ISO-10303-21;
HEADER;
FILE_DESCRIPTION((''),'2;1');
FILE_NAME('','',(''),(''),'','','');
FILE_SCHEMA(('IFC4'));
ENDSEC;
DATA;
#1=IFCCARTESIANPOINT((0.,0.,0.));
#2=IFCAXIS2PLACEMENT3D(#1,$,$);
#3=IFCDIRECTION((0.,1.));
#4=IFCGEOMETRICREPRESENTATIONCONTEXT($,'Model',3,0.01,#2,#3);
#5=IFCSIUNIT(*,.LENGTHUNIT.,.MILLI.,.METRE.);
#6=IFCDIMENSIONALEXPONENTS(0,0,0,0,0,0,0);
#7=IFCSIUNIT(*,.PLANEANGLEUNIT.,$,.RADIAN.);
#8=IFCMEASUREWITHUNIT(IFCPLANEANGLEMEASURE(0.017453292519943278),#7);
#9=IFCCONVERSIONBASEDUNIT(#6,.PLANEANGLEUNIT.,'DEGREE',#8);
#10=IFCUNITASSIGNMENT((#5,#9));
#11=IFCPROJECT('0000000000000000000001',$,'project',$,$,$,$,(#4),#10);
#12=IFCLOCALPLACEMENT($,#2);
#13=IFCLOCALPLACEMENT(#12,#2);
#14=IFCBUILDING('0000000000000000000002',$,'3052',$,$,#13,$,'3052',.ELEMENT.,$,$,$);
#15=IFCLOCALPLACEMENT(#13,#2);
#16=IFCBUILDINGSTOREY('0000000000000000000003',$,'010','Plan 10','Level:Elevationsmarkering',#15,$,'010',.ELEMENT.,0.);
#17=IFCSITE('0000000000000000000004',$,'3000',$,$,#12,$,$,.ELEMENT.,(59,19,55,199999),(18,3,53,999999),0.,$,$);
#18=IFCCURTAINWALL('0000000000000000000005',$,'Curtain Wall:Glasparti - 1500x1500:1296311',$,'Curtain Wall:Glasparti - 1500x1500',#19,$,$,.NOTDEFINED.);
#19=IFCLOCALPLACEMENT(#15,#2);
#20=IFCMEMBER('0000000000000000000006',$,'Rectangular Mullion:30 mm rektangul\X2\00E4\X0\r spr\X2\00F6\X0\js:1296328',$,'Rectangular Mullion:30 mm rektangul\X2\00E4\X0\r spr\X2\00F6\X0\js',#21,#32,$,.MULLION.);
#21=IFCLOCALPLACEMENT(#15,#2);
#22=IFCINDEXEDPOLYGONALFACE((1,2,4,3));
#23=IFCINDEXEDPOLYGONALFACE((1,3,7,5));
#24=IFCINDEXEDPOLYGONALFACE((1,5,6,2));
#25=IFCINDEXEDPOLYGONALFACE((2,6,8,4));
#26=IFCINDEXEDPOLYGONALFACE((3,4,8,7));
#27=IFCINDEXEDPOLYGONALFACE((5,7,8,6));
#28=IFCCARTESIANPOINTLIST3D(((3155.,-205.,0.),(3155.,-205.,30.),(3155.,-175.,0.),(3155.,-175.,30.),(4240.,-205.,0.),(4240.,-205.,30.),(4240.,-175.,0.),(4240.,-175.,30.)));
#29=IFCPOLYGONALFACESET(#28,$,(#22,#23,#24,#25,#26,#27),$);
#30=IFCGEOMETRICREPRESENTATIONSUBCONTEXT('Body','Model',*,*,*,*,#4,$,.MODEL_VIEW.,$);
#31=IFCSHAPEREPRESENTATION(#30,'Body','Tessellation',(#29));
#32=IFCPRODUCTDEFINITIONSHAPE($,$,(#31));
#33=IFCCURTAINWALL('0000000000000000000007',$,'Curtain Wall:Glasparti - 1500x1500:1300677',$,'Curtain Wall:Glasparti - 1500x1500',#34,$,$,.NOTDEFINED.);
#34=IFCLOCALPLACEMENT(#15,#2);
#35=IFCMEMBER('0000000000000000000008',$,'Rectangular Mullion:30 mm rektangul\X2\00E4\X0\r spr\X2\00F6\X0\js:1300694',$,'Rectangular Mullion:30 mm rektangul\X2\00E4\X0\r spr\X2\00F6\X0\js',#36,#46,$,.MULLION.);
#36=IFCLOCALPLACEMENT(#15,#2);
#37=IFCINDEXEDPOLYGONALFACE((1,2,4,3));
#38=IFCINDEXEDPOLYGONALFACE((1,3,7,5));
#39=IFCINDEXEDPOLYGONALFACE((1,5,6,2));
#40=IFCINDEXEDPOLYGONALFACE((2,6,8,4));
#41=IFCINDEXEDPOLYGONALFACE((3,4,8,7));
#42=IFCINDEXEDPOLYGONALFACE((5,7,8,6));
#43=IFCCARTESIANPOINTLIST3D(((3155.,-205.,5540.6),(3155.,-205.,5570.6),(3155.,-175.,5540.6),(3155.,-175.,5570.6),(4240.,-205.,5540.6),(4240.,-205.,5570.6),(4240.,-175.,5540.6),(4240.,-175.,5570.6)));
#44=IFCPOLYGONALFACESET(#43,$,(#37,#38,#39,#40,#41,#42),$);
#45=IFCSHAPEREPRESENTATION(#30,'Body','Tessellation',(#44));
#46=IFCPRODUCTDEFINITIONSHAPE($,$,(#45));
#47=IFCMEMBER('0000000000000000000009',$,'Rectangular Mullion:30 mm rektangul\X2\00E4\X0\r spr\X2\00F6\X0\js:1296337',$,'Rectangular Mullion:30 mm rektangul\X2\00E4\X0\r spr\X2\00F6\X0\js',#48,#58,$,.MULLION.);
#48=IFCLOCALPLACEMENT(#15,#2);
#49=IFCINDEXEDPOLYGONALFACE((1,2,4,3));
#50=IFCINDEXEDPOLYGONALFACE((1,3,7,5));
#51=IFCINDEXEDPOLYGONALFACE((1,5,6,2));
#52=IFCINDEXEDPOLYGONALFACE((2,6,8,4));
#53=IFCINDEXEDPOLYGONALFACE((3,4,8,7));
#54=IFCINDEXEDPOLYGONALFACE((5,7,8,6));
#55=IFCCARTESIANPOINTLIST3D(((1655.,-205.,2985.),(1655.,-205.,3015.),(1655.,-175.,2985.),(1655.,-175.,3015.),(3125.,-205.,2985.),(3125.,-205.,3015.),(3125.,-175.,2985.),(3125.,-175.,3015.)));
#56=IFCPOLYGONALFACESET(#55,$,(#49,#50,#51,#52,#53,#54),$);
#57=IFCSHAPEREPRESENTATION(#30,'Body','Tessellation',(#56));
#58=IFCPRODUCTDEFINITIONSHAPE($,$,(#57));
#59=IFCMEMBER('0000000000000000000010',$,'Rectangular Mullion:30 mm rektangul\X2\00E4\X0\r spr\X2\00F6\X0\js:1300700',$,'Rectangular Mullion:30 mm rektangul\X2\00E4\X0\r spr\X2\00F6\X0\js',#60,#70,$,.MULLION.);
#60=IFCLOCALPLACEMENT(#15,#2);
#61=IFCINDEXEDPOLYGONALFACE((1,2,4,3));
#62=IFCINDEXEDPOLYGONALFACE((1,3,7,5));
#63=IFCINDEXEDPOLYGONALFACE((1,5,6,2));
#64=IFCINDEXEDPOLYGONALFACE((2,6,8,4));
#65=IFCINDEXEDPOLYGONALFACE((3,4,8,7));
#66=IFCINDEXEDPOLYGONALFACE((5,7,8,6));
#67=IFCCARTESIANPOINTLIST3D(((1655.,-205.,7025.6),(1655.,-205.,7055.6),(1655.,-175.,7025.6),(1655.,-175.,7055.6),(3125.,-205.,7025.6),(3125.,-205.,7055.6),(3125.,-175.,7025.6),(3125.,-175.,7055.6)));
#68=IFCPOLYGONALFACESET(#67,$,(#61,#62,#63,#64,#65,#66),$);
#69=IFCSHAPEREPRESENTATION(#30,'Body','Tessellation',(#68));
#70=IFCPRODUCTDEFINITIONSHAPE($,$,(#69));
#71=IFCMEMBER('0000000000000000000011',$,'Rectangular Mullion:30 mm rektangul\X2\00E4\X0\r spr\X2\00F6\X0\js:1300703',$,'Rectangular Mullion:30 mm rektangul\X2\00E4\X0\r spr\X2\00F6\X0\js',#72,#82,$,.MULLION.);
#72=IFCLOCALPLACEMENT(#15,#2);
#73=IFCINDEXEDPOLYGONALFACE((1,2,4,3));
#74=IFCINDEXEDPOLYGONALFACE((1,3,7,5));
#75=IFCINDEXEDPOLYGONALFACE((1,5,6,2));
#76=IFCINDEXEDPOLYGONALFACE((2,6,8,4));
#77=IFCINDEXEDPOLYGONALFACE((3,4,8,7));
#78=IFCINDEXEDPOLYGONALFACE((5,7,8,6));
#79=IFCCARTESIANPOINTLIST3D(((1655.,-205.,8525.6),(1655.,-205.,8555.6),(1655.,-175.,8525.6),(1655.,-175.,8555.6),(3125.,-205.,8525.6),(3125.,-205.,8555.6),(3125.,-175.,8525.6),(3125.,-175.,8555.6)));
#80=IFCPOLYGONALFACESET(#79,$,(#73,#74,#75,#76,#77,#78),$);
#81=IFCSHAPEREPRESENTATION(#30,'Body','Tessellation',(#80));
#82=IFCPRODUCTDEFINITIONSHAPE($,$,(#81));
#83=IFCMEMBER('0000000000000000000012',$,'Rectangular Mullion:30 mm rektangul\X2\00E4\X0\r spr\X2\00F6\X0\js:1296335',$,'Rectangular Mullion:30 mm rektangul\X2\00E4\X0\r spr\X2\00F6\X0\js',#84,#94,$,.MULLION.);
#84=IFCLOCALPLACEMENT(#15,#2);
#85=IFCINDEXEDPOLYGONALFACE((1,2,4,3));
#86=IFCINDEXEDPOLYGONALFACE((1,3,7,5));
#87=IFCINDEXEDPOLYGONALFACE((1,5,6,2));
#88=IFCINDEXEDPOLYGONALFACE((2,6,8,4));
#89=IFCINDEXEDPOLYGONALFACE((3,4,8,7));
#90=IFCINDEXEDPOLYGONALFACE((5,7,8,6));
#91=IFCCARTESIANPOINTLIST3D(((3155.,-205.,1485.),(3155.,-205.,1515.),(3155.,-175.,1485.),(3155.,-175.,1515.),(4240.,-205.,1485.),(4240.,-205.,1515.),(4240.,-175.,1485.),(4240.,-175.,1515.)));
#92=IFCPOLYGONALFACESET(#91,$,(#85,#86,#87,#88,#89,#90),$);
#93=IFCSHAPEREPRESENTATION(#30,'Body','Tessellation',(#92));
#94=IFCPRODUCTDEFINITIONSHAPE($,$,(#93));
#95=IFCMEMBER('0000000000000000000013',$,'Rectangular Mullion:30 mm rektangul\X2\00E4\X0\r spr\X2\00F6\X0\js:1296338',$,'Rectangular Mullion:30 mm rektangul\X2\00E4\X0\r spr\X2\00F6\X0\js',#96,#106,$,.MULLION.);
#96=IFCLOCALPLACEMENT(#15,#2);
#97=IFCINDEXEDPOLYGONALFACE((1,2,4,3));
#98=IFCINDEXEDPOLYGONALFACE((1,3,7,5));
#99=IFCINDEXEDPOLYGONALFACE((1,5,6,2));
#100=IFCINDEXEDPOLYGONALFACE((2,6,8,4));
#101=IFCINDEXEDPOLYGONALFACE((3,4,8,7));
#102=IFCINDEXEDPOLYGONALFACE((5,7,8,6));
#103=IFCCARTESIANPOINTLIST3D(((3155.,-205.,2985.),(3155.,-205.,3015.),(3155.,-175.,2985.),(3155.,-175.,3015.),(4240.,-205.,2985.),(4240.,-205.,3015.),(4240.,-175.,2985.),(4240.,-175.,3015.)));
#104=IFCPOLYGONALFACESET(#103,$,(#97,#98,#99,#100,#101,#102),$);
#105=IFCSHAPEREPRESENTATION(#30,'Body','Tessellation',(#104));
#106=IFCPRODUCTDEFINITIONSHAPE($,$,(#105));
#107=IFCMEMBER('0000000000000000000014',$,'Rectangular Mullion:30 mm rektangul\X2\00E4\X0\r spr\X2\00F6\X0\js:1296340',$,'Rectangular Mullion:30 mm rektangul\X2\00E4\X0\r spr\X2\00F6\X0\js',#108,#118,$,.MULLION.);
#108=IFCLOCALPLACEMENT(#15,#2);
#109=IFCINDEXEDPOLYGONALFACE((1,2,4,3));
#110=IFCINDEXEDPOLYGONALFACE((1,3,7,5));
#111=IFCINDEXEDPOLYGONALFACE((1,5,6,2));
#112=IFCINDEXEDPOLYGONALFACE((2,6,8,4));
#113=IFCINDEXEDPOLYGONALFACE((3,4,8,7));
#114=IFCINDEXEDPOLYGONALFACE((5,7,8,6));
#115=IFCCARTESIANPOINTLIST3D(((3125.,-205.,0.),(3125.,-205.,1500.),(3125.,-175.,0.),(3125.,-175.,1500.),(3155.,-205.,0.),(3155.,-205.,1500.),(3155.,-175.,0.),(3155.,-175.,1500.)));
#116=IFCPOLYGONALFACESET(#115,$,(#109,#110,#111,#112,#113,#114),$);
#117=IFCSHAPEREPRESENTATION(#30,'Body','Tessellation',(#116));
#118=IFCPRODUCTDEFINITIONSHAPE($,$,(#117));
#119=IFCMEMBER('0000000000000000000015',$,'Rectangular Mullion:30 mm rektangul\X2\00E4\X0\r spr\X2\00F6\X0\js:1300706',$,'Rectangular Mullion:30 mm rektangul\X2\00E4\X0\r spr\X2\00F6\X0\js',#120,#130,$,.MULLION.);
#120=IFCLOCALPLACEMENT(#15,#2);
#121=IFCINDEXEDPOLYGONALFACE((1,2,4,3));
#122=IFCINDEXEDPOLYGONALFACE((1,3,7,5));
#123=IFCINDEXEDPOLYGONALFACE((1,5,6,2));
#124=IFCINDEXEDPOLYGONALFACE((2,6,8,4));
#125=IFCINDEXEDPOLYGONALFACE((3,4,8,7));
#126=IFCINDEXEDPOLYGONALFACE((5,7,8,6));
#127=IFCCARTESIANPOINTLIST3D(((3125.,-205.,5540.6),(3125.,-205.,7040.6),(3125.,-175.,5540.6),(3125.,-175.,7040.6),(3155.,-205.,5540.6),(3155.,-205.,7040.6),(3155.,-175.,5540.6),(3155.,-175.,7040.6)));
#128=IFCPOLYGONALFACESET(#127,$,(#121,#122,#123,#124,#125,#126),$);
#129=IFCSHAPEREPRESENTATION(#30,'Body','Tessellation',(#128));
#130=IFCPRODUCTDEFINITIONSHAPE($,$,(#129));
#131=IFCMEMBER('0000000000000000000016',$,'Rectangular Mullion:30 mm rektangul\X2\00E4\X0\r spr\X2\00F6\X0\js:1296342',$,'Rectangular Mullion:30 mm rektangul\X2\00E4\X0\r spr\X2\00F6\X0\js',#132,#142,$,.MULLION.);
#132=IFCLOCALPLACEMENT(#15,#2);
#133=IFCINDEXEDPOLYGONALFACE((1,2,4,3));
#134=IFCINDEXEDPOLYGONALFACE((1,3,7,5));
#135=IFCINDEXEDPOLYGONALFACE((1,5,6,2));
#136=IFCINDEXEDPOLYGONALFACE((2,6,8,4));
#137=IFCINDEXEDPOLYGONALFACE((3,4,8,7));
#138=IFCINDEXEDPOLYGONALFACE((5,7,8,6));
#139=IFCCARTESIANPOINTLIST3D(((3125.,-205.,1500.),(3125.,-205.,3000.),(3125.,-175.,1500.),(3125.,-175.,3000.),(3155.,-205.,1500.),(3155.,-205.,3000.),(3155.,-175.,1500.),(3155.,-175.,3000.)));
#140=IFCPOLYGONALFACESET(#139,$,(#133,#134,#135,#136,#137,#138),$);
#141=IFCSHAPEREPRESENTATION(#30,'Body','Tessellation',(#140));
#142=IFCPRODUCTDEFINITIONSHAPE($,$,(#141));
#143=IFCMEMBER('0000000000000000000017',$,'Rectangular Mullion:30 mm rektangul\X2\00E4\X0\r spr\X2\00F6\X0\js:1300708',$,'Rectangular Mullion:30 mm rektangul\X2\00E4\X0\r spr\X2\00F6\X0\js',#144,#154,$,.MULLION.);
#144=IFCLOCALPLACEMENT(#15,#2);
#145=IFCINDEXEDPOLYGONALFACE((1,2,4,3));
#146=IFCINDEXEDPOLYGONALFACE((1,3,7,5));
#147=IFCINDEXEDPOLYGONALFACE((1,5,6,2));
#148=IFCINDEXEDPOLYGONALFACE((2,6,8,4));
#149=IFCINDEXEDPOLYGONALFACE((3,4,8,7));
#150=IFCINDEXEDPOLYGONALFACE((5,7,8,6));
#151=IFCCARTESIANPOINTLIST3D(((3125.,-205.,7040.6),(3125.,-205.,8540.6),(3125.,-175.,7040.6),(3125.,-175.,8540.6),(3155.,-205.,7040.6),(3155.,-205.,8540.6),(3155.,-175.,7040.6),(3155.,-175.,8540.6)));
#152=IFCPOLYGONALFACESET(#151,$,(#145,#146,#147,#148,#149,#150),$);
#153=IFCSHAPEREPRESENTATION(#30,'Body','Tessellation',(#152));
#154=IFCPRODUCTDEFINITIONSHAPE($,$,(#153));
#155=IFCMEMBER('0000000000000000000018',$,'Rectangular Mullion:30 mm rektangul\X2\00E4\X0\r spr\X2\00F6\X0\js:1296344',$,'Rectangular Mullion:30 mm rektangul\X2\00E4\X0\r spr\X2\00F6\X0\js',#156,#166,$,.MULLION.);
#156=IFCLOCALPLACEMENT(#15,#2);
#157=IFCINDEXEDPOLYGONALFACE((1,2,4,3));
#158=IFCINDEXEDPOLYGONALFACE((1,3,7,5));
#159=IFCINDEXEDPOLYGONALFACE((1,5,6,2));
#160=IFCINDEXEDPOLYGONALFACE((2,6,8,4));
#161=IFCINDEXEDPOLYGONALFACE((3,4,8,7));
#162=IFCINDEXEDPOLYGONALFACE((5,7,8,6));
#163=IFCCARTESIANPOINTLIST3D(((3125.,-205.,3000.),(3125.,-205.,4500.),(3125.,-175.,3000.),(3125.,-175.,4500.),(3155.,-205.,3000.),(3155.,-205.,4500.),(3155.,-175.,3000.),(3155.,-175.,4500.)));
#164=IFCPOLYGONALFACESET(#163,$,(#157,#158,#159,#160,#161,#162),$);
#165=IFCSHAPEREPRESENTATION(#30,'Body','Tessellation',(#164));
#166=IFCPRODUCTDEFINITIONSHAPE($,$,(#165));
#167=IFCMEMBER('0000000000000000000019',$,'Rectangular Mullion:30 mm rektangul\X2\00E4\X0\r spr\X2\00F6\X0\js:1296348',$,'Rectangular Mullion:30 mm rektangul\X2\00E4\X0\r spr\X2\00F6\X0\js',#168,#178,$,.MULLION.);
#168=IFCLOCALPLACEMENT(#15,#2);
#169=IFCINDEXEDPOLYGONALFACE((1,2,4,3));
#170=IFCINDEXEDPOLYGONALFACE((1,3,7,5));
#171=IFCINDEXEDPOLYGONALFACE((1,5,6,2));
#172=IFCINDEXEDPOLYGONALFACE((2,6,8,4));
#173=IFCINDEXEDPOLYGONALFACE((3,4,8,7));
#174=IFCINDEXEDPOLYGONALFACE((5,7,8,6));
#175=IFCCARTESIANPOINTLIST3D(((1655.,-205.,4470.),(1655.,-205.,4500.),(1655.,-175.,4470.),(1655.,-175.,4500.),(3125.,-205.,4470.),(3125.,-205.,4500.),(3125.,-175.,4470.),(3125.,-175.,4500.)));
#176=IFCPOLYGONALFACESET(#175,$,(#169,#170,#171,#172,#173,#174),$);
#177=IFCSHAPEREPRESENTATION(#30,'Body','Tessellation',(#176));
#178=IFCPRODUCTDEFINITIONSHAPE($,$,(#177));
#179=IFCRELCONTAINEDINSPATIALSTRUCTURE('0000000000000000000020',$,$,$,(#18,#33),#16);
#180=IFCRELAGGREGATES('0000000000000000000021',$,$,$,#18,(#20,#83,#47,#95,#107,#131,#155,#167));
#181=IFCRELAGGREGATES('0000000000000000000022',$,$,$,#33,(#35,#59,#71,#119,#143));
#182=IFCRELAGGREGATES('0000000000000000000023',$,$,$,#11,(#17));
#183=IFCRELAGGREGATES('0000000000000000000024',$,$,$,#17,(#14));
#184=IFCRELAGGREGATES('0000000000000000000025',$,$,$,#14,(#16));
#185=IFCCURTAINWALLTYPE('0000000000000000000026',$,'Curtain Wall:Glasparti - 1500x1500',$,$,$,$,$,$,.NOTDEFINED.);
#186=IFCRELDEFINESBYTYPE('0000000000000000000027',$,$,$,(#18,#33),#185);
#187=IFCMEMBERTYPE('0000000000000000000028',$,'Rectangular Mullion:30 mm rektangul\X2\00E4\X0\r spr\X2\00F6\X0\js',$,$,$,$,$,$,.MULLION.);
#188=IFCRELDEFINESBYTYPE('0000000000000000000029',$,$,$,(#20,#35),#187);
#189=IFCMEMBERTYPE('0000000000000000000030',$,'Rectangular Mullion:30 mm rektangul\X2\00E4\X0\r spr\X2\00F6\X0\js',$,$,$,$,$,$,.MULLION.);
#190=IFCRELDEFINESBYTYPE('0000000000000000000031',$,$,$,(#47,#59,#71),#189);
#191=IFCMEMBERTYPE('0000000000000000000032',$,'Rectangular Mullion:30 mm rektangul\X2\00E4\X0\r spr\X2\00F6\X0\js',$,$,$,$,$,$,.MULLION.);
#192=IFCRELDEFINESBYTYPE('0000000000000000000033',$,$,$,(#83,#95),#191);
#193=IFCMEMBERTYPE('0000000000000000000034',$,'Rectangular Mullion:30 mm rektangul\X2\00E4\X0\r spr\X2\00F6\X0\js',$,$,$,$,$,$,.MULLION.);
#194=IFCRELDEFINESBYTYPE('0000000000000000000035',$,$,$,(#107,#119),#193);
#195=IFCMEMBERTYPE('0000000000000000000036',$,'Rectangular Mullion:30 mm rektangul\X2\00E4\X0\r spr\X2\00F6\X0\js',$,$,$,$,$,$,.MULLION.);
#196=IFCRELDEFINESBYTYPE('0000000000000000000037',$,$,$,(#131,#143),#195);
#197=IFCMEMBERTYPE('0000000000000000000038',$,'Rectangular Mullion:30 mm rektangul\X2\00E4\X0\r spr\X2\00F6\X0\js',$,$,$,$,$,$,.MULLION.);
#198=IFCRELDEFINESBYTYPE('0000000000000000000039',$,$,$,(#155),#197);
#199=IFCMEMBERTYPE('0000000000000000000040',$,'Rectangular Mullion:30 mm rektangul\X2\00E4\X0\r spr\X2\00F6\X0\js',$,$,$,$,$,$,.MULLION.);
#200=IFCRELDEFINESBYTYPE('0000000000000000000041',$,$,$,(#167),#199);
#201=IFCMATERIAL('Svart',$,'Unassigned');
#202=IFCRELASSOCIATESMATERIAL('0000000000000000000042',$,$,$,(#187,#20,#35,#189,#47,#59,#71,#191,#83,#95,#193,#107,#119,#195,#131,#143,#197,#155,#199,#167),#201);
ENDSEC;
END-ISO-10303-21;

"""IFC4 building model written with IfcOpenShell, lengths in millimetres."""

from ifc_helpers import new_model, entity, si_unit, converted_unit, direction, frame, origin, place, context, subcontext, project, spatial, indexed_curve, outline, extrude, source, transform, mapped, material, type_object, type_shapes, element, aggregate, save


model = new_model("IFC4")

# Units and contexts
model_context = context("Model", 3, precision=0.01, world=origin(), true_north=direction((0.0, 1.0)))
body_context = subcontext(model_context, "Body", "Model", "MODEL_VIEW")
ifc_project = project(units=[si_unit("LENGTHUNIT", "METRE", prefix="MILLI"), converted_unit("PLANEANGLEUNIT", "DEGREE", entity("IfcPlaneAngleMeasure", 0.017453292519943278), si_unit("PLANEANGLEUNIT", "RADIAN"), dimensions=[0, 0, 0, 0, 0, 0, 0])], contexts=[model_context])

# Site, building, storey
site_placement = place(None, origin())
site = spatial("IfcSite", under=ifc_project, at=site_placement, Name="3000", CompositionType="ELEMENT", RefLatitude=(59, 19, 55, 199999), RefLongitude=(18, 3, 53, 999999), RefElevation=0.0)
building_placement = place(site_placement, origin())
building = spatial("IfcBuilding", under=site, at=building_placement, Name="3052", LongName="3052", CompositionType="ELEMENT")
storey_placement = place(building_placement, origin())
storey = spatial("IfcBuildingStorey", under=building, at=storey_placement, Name="010", Description="Plan 10", ObjectType="Level:Elevationsmarkering", LongName="010", CompositionType="ELEMENT", Elevation=0.0)

# Curtain walls, members
curtain_wall_type = type_object("IfcCurtainWallType", Name="Curtain Wall:Glasparti - 1500x1500", PredefinedType="NOTDEFINED")
curtain_wall_1_placement = place(storey_placement, origin())
curtain_wall_1 = element("IfcCurtainWall", 1, at=curtain_wall_1_placement, inside=storey, type_object=curtain_wall_type, Name="Curtain Wall:Glasparti - 1500x1500:1296311", ObjectType="Curtain Wall:Glasparti - 1500x1500", PredefinedType="NOTDEFINED")
ifc_material_1 = material(Name="Svart", Category="Unassigned")
member_type_1 = type_object("IfcMemberType", Name="Rectangular Mullion:30 mm rektangulär spröjs", PredefinedType="MULLION", material=ifc_material_1)
shared_shape_1 = source(origin(), body_context, "Body", "SweptSolid", [
    extrude(outline(indexed_curve([(-15.0, -15.0), (15.0, -15.0), (15.0, 15.0), (-15.0, 15.0), (-15.0, -15.0)], self_intersect=False)), frame((-15.0, 0.0, -1085.0), z_axis=(0.0, 0.0, 1.0), x_axis=(-1.0, 0.0, 0.0)), (0.0, 0.0, 1.0), 1085.0),
])
type_shapes(member_type_1, [shared_shape_1])
member_1_placement = place(curtain_wall_1_placement, frame((3155.0, -190.0, 0.0), z_axis=(-1.0, 0.0, 0.0), x_axis=(0.0, 0.0, -1.0)))
member_1 = element("IfcMember", 2, at=member_1_placement, type_object=member_type_1, material=ifc_material_1, Name="Rectangular Mullion:30 mm rektangulär spröjs:1296328", ObjectType="Rectangular Mullion:30 mm rektangulär spröjs", PredefinedType="MULLION", context=body_context, shape_type="MappedRepresentation", body=[
    mapped(shared_shape_1, transform((0.0, 0.0, 0.0), scale=1.0)),
])
curtain_wall_2_placement = place(storey_placement, origin())
curtain_wall_2 = element("IfcCurtainWall", 3, at=curtain_wall_2_placement, inside=storey, type_object=curtain_wall_type, Name="Curtain Wall:Glasparti - 1500x1500:1300677", ObjectType="Curtain Wall:Glasparti - 1500x1500", PredefinedType="NOTDEFINED")
member_2_placement = place(curtain_wall_2_placement, frame((3155.0, -190.0, 5540.6), z_axis=(-1.0, 0.0, 0.0), x_axis=(0.0, 0.0, -1.0)))
member_2 = element("IfcMember", 4, at=member_2_placement, type_object=member_type_1, material=ifc_material_1, Name="Rectangular Mullion:30 mm rektangulär spröjs:1300694", ObjectType="Rectangular Mullion:30 mm rektangulär spröjs", PredefinedType="MULLION", context=body_context, shape_type="MappedRepresentation", body=[
    mapped(shared_shape_1, transform((0.0, 0.0, 0.0), scale=1.0)),
])

# Members
member_type_2 = type_object("IfcMemberType", Name="Rectangular Mullion:30 mm rektangulär spröjs", PredefinedType="MULLION", material=ifc_material_1)
shared_shape_2 = source(origin(), body_context, "Body", "SweptSolid", [
    extrude(outline(indexed_curve([(-15.0, -15.0), (15.0, -15.0), (15.0, 15.0), (-15.0, 15.0), (-15.0, -15.0)], self_intersect=False)), frame((0.0, 0.0, -1470.0), z_axis=(0.0, 0.0, 1.0), x_axis=(-1.0, 0.0, 0.0)), (0.0, 0.0, 1.0), 1470.0),
])
type_shapes(member_type_2, [shared_shape_2])
member_3_placement = place(curtain_wall_1_placement, frame((3125.0, -190.0, 3000.0), z_axis=(1.0, 0.0, 0.0), x_axis=(0.0, 0.0, 1.0)))
member_3 = element("IfcMember", 5, at=member_3_placement, type_object=member_type_2, material=ifc_material_1, Name="Rectangular Mullion:30 mm rektangulär spröjs:1296337", ObjectType="Rectangular Mullion:30 mm rektangulär spröjs", PredefinedType="MULLION", context=body_context, shape_type="MappedRepresentation", body=[
    mapped(shared_shape_2, transform((0.0, 0.0, 0.0), scale=1.0)),
])
member_4_placement = place(curtain_wall_2_placement, frame((3125.0, -190.0, 7040.6), z_axis=(1.0, 0.0, 0.0), x_axis=(0.0, 0.0, 1.0)))
member_4 = element("IfcMember", 6, at=member_4_placement, type_object=member_type_2, material=ifc_material_1, Name="Rectangular Mullion:30 mm rektangulär spröjs:1300700", ObjectType="Rectangular Mullion:30 mm rektangulär spröjs", PredefinedType="MULLION", context=body_context, shape_type="MappedRepresentation", body=[
    mapped(shared_shape_2, transform((0.0, 0.0, 0.0), scale=1.0)),
])
member_5_placement = place(curtain_wall_2_placement, frame((3125.0, -190.0, 8540.6), z_axis=(1.0, 0.0, 0.0), x_axis=(0.0, 0.0, 1.0)))
member_5 = element("IfcMember", 7, at=member_5_placement, type_object=member_type_2, material=ifc_material_1, Name="Rectangular Mullion:30 mm rektangulär spröjs:1300703", ObjectType="Rectangular Mullion:30 mm rektangulär spröjs", PredefinedType="MULLION", context=body_context, shape_type="MappedRepresentation", body=[
    mapped(shared_shape_2, transform((0.0, 0.0, 0.0), scale=1.0)),
])
member_type_3 = type_object("IfcMemberType", Name="Rectangular Mullion:30 mm rektangulär spröjs", PredefinedType="MULLION", material=ifc_material_1)
shared_shape_3 = source(origin(), body_context, "Body", "SweptSolid", [
    extrude(outline(indexed_curve([(-15.0, -15.0), (15.0, -15.0), (15.0, 15.0), (-15.0, 15.0), (-15.0, -15.0)], self_intersect=False)), frame((0.0, 0.0, -1085.0), z_axis=(0.0, 0.0, 1.0), x_axis=(-1.0, 0.0, 0.0)), (0.0, 0.0, 1.0), 1085.0),
])
type_shapes(member_type_3, [shared_shape_3])
member_6_placement = place(curtain_wall_1_placement, frame((4240.0, -190.0, 1500.0), z_axis=(1.0, 0.0, 0.0), x_axis=(0.0, 0.0, 1.0)))
member_6 = element("IfcMember", 8, at=member_6_placement, type_object=member_type_3, material=ifc_material_1, Name="Rectangular Mullion:30 mm rektangulär spröjs:1296335", ObjectType="Rectangular Mullion:30 mm rektangulär spröjs", PredefinedType="MULLION", context=body_context, shape_type="MappedRepresentation", body=[
    mapped(shared_shape_3, transform((0.0, 0.0, 0.0), scale=1.0)),
])
member_7_placement = place(curtain_wall_1_placement, frame((4240.0, -190.0, 3000.0), z_axis=(1.0, 0.0, 0.0), x_axis=(0.0, 0.0, 1.0)))
member_7 = element("IfcMember", 9, at=member_7_placement, type_object=member_type_3, material=ifc_material_1, Name="Rectangular Mullion:30 mm rektangulär spröjs:1296338", ObjectType="Rectangular Mullion:30 mm rektangulär spröjs", PredefinedType="MULLION", context=body_context, shape_type="MappedRepresentation", body=[
    mapped(shared_shape_3, transform((0.0, 0.0, 0.0), scale=1.0)),
])
member_type_4 = type_object("IfcMemberType", Name="Rectangular Mullion:30 mm rektangulär spröjs", PredefinedType="MULLION", material=ifc_material_1)
shared_shape_4 = source(origin(), body_context, "Body", "SweptSolid", [
    extrude(outline(indexed_curve([(-15.0, -15.0), (15.0, -15.0), (15.0, 15.0), (-15.0, 15.0), (-15.0, -15.0)], self_intersect=False)), frame((0.0, 0.0, -1500.0), z_axis=(0.0, 0.0, 1.0), x_axis=(-1.0, 0.0, 0.0)), (0.0, 0.0, 1.0), 1500.0),
])
type_shapes(member_type_4, [shared_shape_4])
member_8_placement = place(curtain_wall_1_placement, frame((3140.0, -190.0, 0.0), z_axis=(0.0, 0.0, -1.0), x_axis=(1.0, 0.0, 0.0)))
member_8 = element("IfcMember", 10, at=member_8_placement, type_object=member_type_4, material=ifc_material_1, Name="Rectangular Mullion:30 mm rektangulär spröjs:1296340", ObjectType="Rectangular Mullion:30 mm rektangulär spröjs", PredefinedType="MULLION", context=body_context, shape_type="MappedRepresentation", body=[
    mapped(shared_shape_4, transform((0.0, 0.0, 0.0), scale=1.0)),
])
member_9_placement = place(curtain_wall_2_placement, frame((3140.0, -190.0, 5540.6), z_axis=(0.0, 0.0, -1.0), x_axis=(1.0, 0.0, 0.0)))
member_9 = element("IfcMember", 11, at=member_9_placement, type_object=member_type_4, material=ifc_material_1, Name="Rectangular Mullion:30 mm rektangulär spröjs:1300706", ObjectType="Rectangular Mullion:30 mm rektangulär spröjs", PredefinedType="MULLION", context=body_context, shape_type="MappedRepresentation", body=[
    mapped(shared_shape_4, transform((0.0, 0.0, 0.0), scale=1.0)),
])
member_type_5 = type_object("IfcMemberType", Name="Rectangular Mullion:30 mm rektangulär spröjs", PredefinedType="MULLION", material=ifc_material_1)
shared_shape_5 = source(origin(), body_context, "Body", "SweptSolid", [
    extrude(outline(indexed_curve([(-15.0, -15.0), (15.0, -15.0), (15.0, 15.0), (-15.0, 15.0), (-15.0, -15.0)], self_intersect=False)), frame((0.0, 0.0, -1500.0), z_axis=(0.0, 0.0, 1.0), x_axis=(-1.0, 0.0, 0.0)), (0.0, 0.0, 1.0), 1500.0),
])
type_shapes(member_type_5, [shared_shape_5])
member_10_placement = place(curtain_wall_1_placement, frame((3140.0, -190.0, 1500.0), z_axis=(0.0, 0.0, -1.0), x_axis=(1.0, 0.0, 0.0)))
member_10 = element("IfcMember", 12, at=member_10_placement, type_object=member_type_5, material=ifc_material_1, Name="Rectangular Mullion:30 mm rektangulär spröjs:1296342", ObjectType="Rectangular Mullion:30 mm rektangulär spröjs", PredefinedType="MULLION", context=body_context, shape_type="MappedRepresentation", body=[
    mapped(shared_shape_5, transform((0.0, 0.0, 0.0), scale=1.0)),
])
member_11_placement = place(curtain_wall_2_placement, frame((3140.0, -190.0, 7040.6), z_axis=(0.0, 0.0, -1.0), x_axis=(1.0, 0.0, 0.0)))
member_11 = element("IfcMember", 13, at=member_11_placement, type_object=member_type_5, material=ifc_material_1, Name="Rectangular Mullion:30 mm rektangulär spröjs:1300708", ObjectType="Rectangular Mullion:30 mm rektangulär spröjs", PredefinedType="MULLION", context=body_context, shape_type="MappedRepresentation", body=[
    mapped(shared_shape_5, transform((0.0, 0.0, 0.0), scale=1.0)),
])
member_type_6 = type_object("IfcMemberType", Name="Rectangular Mullion:30 mm rektangulär spröjs", PredefinedType="MULLION", material=ifc_material_1)
shared_shape_6 = source(origin(), body_context, "Body", "SweptSolid", [
    extrude(outline(indexed_curve([(-15.0, -15.0), (15.0, -15.0), (15.0, 15.0), (-15.0, 15.0), (-15.0, -15.0)], self_intersect=False)), frame((0.0, 0.0, -1500.0), z_axis=(0.0, 0.0, 1.0), x_axis=(-1.0, 0.0, 0.0)), (0.0, 0.0, 1.0), 1500.0),
])
type_shapes(member_type_6, [shared_shape_6])
member_12_placement = place(curtain_wall_1_placement, frame((3140.0, -190.0, 3000.0), z_axis=(0.0, 0.0, -1.0), x_axis=(1.0, 0.0, 0.0)))
member_12 = element("IfcMember", 14, at=member_12_placement, type_object=member_type_6, material=ifc_material_1, Name="Rectangular Mullion:30 mm rektangulär spröjs:1296344", ObjectType="Rectangular Mullion:30 mm rektangulär spröjs", PredefinedType="MULLION", context=body_context, shape_type="MappedRepresentation", body=[
    mapped(shared_shape_6, transform((0.0, 0.0, 0.0), scale=1.0)),
])
member_type_7 = type_object("IfcMemberType", Name="Rectangular Mullion:30 mm rektangulär spröjs", PredefinedType="MULLION", material=ifc_material_1)
shared_shape_7 = source(origin(), body_context, "Body", "SweptSolid", [
    extrude(outline(indexed_curve([(-15.0, -15.0), (15.0, -15.0), (15.0, 15.0), (-15.0, 15.0), (-15.0, -15.0)], self_intersect=False)), frame((-15.0, 0.0, -1470.0), z_axis=(0.0, 0.0, 1.0), x_axis=(-1.0, 0.0, 0.0)), (0.0, 0.0, 1.0), 1470.0),
])
type_shapes(member_type_7, [shared_shape_7])
member_13_placement = place(curtain_wall_1_placement, frame((3125.0, -190.0, 4500.0), z_axis=(1.0, 0.0, 0.0), x_axis=(0.0, 0.0, 1.0)))
member_13 = element("IfcMember", 15, at=member_13_placement, type_object=member_type_7, material=ifc_material_1, Name="Rectangular Mullion:30 mm rektangulär spröjs:1296348", ObjectType="Rectangular Mullion:30 mm rektangulär spröjs", PredefinedType="MULLION", context=body_context, shape_type="MappedRepresentation", body=[
    mapped(shared_shape_7, transform((0.0, 0.0, 0.0), scale=1.0)),
])

aggregate(curtain_wall_1, [member_1, member_6, member_3, member_7, member_8, member_10, member_12, member_13])
aggregate(curtain_wall_2, [member_2, member_4, member_5, member_9, member_11])

save(model, "model.ifc")
